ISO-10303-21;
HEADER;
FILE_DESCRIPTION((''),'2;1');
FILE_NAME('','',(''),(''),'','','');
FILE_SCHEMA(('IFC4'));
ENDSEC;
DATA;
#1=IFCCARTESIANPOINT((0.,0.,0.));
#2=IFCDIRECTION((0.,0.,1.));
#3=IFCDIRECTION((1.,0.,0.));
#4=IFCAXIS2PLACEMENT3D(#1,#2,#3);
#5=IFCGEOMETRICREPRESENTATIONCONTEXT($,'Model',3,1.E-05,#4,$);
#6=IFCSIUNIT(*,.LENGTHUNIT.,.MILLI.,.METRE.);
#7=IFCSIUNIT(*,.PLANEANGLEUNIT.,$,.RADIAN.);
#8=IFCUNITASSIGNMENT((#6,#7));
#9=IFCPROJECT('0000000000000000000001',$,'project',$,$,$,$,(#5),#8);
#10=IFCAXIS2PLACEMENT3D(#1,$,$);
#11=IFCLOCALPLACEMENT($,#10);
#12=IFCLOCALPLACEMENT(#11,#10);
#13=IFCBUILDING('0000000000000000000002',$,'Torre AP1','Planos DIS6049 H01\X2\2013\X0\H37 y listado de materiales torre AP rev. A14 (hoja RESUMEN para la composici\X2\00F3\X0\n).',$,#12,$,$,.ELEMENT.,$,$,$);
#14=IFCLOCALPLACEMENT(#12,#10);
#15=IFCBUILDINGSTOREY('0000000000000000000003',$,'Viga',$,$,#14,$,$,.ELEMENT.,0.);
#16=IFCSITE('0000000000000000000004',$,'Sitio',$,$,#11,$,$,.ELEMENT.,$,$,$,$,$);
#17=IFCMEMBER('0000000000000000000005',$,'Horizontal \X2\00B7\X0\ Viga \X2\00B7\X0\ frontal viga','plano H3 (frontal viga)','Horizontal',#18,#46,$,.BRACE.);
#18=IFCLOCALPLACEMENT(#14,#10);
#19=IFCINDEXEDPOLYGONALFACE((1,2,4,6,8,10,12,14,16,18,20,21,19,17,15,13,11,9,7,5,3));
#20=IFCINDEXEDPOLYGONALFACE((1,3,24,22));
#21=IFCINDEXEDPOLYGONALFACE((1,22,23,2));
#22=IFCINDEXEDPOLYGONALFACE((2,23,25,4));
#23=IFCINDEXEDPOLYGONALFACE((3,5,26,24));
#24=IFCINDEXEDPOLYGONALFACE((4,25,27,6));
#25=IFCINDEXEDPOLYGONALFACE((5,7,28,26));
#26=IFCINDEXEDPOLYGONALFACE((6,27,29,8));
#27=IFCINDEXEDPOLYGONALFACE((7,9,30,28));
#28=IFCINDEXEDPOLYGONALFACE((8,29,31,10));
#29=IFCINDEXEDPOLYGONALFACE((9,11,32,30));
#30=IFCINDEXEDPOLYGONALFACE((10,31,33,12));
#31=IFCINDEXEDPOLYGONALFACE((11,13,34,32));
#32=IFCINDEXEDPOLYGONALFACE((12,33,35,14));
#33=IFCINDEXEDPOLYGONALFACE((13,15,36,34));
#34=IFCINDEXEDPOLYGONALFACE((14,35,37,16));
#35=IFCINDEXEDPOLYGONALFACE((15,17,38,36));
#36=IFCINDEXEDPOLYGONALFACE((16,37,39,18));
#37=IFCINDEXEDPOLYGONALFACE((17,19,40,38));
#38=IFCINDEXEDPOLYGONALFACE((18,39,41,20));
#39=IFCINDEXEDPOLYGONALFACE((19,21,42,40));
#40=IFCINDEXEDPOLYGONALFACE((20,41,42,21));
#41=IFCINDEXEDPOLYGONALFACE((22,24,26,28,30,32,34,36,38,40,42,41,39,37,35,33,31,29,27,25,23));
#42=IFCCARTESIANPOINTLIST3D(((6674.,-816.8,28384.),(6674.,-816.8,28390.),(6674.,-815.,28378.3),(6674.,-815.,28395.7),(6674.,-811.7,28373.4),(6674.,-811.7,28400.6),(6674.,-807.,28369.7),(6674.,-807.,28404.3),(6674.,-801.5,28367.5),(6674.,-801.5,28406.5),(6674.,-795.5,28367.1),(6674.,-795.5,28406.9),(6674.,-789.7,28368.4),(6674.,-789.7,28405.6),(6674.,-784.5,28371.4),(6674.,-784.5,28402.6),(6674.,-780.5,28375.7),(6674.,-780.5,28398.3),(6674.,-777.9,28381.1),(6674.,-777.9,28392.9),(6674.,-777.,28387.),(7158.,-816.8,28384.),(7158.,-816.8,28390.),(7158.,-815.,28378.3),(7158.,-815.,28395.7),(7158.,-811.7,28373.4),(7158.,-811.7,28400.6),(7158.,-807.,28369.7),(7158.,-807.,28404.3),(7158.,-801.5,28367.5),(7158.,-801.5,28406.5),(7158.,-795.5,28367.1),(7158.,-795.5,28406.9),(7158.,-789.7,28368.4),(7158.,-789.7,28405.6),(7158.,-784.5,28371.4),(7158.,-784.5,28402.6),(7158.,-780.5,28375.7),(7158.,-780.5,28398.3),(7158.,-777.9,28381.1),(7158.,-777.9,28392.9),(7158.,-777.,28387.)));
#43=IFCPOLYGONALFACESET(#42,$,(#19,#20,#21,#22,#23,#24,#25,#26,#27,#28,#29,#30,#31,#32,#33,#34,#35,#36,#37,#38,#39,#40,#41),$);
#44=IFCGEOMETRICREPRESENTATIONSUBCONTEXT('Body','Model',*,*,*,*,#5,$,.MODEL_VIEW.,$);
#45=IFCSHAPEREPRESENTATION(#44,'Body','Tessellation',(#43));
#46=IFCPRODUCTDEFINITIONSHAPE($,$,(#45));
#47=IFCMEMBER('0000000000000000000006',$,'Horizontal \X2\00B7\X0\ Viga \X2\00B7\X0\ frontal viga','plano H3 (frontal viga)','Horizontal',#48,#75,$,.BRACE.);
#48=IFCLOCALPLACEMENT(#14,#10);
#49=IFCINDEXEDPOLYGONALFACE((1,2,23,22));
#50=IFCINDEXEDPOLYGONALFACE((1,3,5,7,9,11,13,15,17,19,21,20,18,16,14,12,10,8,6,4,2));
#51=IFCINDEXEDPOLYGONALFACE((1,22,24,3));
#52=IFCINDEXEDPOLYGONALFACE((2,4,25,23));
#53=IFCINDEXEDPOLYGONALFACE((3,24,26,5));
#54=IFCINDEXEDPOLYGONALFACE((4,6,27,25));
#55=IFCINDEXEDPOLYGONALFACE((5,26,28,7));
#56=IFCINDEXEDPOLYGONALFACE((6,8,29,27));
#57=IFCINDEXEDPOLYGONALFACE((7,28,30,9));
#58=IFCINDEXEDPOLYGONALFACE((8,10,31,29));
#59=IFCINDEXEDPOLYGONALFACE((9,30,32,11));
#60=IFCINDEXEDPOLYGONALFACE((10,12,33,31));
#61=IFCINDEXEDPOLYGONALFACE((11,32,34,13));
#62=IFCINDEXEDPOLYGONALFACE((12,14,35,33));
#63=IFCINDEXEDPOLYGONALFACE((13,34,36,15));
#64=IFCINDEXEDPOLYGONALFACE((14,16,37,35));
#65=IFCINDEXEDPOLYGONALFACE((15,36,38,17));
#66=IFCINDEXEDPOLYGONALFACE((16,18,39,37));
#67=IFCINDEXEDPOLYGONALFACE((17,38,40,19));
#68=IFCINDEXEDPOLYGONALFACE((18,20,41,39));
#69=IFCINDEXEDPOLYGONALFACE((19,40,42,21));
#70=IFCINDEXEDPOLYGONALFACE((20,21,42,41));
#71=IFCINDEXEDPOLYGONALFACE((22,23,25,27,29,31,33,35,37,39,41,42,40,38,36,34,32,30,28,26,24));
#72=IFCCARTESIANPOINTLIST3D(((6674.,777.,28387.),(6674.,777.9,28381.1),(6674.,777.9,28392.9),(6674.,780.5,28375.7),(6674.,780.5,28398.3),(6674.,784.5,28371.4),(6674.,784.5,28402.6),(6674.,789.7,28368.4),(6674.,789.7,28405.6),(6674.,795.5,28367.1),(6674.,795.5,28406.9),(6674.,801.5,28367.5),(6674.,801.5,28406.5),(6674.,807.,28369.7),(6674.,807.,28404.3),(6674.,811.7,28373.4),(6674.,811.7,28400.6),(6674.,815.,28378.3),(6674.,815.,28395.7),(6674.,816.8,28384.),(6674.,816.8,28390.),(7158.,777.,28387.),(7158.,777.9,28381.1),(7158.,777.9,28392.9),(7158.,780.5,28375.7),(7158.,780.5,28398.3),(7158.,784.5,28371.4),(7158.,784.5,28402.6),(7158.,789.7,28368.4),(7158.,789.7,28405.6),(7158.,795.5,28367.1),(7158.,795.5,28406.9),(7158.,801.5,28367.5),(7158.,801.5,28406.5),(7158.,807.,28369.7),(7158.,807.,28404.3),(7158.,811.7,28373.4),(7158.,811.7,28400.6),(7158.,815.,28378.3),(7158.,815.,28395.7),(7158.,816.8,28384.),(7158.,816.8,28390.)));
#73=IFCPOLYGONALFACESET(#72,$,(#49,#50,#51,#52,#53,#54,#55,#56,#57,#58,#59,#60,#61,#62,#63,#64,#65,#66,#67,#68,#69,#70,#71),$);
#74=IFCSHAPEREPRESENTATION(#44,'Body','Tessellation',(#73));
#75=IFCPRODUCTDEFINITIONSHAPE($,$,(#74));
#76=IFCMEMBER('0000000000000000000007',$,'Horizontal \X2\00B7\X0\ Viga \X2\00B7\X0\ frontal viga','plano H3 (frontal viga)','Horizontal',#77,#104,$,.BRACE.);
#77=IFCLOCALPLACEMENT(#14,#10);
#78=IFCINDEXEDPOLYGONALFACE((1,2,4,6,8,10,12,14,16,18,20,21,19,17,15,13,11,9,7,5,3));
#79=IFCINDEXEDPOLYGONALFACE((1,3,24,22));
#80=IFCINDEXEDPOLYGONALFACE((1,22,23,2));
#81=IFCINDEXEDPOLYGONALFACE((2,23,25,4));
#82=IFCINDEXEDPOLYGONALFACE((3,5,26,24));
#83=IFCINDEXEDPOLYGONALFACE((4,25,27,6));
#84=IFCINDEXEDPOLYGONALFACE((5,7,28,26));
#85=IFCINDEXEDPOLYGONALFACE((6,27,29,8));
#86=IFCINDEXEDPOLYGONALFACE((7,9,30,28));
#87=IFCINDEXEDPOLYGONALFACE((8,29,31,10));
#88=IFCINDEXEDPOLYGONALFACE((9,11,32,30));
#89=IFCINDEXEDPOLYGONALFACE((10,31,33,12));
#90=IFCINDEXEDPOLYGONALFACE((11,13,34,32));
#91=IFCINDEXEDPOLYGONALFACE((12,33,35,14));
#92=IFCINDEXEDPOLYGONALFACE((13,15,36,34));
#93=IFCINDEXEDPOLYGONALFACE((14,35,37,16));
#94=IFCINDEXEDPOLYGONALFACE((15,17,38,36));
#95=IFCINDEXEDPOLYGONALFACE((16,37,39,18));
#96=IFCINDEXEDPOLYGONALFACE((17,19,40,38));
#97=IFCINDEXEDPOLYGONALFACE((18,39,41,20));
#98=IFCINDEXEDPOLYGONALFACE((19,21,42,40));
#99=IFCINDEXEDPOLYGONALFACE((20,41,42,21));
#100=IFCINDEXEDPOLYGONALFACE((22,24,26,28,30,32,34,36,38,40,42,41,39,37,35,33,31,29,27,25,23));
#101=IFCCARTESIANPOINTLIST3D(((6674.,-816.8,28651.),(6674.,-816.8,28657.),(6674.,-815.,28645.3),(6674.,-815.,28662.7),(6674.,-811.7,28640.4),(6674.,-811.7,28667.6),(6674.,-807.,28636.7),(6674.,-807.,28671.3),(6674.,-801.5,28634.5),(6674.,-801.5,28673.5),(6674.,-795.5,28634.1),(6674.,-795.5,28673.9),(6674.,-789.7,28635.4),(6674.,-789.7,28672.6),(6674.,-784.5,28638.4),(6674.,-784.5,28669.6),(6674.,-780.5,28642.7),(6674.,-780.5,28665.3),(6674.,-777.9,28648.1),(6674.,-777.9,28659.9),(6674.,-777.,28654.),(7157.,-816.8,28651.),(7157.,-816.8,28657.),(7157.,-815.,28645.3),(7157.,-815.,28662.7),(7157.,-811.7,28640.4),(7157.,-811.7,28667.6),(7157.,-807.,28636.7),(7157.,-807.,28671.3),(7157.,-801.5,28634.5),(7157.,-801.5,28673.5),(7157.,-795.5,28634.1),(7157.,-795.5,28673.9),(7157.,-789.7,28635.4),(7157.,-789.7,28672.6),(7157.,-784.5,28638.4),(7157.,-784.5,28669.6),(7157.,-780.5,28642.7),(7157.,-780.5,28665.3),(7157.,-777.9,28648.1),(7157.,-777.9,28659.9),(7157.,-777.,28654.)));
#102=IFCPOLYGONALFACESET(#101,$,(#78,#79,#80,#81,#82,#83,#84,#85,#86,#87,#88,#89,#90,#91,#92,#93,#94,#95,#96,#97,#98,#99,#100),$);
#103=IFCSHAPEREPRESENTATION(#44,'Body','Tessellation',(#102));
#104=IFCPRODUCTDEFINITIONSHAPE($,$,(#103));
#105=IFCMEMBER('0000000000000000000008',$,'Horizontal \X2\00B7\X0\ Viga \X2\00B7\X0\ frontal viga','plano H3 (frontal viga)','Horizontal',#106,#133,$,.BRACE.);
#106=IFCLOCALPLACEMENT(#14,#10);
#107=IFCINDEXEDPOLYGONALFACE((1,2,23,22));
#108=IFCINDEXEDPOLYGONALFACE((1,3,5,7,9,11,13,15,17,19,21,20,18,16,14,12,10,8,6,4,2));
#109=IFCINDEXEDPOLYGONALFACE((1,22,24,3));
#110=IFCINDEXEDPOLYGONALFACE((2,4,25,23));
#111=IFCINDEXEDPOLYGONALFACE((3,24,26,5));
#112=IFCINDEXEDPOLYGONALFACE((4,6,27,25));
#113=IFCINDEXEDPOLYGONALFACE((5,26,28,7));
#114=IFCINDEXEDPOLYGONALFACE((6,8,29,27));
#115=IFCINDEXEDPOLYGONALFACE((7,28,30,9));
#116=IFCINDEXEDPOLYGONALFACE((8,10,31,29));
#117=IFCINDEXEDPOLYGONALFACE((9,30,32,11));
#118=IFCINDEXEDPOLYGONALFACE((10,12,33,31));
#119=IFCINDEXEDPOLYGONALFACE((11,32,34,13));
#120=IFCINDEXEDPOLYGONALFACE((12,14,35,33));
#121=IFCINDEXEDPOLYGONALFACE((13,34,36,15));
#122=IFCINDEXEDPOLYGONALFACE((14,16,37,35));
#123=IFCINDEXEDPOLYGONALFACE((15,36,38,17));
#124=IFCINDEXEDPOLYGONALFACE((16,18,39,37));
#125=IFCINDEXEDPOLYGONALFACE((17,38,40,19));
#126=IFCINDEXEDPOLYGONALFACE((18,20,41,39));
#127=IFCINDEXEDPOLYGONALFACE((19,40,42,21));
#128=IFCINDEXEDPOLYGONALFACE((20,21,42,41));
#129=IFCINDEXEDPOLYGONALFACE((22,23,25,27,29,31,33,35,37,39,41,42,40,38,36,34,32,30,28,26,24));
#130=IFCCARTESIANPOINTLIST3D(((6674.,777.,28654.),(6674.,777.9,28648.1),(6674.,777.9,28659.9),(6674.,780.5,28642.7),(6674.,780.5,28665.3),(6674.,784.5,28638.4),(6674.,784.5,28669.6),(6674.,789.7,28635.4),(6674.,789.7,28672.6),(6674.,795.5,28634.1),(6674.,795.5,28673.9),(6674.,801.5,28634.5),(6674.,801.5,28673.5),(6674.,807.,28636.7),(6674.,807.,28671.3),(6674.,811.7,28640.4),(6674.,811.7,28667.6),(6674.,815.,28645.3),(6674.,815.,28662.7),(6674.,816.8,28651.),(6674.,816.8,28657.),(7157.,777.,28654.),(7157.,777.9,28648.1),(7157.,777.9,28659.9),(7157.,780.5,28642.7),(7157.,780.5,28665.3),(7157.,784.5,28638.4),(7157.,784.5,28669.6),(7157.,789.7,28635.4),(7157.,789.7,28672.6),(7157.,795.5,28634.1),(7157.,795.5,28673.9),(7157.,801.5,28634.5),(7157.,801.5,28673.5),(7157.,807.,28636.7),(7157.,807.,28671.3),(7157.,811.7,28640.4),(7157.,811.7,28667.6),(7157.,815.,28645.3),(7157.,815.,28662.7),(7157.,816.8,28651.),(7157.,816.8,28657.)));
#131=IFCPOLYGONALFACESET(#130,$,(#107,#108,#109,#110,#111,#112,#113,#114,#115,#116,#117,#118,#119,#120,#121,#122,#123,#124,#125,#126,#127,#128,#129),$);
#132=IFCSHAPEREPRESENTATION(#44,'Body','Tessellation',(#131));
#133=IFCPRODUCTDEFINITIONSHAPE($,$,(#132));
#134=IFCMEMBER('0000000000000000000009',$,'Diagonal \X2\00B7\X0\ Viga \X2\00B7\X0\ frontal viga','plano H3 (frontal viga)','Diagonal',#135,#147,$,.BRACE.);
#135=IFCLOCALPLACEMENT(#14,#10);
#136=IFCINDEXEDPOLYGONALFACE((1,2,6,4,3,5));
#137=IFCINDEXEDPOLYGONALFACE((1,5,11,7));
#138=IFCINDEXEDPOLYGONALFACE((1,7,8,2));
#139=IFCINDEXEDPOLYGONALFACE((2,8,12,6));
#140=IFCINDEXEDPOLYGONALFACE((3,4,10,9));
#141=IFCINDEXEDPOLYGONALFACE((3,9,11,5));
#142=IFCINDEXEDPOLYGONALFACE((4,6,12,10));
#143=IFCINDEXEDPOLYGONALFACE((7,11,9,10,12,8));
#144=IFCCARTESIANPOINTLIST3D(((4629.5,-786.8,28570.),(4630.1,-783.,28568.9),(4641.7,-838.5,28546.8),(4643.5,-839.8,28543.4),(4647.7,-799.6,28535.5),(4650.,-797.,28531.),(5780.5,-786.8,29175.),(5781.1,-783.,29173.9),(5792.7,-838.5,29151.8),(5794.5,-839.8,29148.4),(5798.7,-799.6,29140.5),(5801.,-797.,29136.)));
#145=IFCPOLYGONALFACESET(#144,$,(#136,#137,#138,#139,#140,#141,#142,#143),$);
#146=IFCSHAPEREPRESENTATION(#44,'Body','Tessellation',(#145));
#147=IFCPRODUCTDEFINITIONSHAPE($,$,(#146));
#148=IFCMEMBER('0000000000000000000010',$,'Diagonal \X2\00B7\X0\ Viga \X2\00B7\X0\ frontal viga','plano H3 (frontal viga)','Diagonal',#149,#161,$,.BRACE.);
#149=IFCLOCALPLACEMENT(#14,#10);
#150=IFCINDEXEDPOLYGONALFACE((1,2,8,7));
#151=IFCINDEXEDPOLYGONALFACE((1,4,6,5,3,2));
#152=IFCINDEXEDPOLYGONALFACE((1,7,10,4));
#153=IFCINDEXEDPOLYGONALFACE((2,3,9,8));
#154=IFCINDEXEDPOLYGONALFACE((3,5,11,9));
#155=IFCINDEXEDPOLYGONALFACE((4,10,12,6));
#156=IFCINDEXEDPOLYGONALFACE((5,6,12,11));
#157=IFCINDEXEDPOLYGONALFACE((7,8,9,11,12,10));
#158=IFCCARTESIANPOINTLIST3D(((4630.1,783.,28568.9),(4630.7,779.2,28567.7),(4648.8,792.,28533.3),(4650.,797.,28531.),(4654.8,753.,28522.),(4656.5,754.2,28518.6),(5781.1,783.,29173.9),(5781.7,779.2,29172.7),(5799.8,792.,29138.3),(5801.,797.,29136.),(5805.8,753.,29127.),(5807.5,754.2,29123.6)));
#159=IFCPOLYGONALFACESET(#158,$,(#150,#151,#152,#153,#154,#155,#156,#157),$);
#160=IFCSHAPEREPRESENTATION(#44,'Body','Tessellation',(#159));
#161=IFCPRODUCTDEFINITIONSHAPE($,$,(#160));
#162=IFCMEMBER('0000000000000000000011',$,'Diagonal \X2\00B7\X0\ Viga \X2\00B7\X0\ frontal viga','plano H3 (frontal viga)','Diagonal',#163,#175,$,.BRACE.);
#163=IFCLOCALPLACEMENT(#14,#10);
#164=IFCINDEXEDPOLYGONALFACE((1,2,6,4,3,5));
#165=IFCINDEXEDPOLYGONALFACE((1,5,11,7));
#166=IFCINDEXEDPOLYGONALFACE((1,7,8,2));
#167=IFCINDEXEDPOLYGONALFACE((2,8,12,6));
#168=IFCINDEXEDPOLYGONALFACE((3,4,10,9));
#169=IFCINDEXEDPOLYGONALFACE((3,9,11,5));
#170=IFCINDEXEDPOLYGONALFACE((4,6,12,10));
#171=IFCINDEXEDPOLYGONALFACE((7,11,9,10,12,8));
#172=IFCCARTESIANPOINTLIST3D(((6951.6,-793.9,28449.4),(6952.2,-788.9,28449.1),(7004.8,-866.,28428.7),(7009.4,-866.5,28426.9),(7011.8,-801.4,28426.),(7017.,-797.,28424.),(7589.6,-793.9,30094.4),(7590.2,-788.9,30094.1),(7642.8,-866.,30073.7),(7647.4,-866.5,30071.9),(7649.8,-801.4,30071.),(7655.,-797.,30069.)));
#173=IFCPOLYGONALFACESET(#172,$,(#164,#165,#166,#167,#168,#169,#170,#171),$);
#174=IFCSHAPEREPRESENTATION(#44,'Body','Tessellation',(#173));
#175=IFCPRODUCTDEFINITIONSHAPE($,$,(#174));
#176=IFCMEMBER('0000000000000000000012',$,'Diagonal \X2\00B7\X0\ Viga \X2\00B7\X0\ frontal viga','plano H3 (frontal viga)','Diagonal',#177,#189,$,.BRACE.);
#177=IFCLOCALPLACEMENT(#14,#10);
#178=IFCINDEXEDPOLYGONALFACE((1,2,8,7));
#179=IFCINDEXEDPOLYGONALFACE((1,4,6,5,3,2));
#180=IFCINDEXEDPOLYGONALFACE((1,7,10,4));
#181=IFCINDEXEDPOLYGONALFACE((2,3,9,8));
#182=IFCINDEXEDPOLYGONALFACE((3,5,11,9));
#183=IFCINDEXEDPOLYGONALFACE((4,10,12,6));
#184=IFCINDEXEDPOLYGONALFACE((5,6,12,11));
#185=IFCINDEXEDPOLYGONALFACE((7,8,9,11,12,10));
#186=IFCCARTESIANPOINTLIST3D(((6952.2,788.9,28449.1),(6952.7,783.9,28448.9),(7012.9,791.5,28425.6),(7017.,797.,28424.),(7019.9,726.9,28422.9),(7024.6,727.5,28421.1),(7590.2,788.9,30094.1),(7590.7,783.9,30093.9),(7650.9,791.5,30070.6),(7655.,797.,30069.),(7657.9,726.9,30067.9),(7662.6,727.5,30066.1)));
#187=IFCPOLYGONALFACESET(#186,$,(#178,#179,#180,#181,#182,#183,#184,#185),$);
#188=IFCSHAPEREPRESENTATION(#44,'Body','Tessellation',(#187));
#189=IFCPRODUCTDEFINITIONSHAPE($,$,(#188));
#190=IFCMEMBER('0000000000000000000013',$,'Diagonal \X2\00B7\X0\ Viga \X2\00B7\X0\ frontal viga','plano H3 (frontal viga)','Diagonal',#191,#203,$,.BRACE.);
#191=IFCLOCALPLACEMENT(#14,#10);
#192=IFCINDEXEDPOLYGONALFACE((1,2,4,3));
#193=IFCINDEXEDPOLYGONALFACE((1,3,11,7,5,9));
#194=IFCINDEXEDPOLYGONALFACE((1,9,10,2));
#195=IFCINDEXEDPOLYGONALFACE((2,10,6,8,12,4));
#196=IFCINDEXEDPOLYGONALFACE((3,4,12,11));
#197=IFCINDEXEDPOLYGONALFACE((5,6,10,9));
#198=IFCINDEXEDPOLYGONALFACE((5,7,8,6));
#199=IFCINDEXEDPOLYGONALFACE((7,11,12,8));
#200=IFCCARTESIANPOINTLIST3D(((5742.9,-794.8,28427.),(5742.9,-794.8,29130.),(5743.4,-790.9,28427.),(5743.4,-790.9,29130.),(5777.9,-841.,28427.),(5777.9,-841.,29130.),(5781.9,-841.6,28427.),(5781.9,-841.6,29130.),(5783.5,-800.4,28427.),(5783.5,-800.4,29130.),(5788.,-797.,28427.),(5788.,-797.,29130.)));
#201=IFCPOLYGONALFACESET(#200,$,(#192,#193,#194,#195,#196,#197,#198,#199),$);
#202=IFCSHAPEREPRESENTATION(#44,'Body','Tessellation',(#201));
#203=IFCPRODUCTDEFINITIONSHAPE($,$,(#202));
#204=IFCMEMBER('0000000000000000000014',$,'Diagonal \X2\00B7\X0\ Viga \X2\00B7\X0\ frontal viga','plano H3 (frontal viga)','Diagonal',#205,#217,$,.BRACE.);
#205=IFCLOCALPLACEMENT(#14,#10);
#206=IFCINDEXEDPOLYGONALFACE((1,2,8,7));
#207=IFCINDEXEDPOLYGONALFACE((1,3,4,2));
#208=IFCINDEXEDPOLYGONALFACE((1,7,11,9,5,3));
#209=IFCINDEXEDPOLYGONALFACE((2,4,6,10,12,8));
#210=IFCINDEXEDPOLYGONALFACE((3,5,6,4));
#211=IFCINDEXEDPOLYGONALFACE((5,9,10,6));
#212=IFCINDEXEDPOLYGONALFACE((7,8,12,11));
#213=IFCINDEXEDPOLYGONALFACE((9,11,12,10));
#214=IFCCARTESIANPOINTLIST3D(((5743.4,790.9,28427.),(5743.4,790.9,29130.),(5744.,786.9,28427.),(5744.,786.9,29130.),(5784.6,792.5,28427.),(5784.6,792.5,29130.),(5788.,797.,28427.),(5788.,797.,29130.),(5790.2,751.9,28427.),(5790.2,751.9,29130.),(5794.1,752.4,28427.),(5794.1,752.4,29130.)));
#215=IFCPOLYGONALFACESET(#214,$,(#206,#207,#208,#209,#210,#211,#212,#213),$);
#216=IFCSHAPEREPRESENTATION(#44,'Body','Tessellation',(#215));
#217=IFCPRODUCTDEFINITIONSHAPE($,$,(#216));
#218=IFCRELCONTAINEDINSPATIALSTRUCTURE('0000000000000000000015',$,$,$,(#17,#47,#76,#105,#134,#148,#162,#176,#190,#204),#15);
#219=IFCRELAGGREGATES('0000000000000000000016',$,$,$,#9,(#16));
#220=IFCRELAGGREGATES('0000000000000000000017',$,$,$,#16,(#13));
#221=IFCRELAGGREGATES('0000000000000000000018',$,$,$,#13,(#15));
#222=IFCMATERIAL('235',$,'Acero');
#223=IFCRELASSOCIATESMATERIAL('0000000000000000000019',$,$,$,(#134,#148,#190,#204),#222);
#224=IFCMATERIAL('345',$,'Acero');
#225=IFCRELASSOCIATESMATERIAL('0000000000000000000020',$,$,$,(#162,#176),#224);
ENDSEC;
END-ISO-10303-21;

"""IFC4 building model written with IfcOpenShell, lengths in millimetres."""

from ifc_helpers import new_model, si_unit, frame, frame_2d, origin, origin_with_axes, place, context, subcontext, project, spatial, circle, l_section, extrude, material, element, save


model = new_model("IFC4")

# Units and contexts
model_context = context("Model", 3, precision=1e-05, world=origin_with_axes())
body_context = subcontext(model_context, "Body", "Model", "MODEL_VIEW")
ifc_project = project(units=[si_unit("LENGTHUNIT", "METRE", prefix="MILLI"), si_unit("PLANEANGLEUNIT", "RADIAN")], contexts=[model_context])

# Site, building, storey
site_placement = place(None, origin())
site = spatial("IfcSite", under=ifc_project, at=site_placement, Name="Sitio", CompositionType="ELEMENT")
building_placement = place(site_placement, origin())
building = spatial("IfcBuilding", under=site, at=building_placement, Name="Torre AP1", Description="Planos DIS6049 H01–H37 y listado de materiales torre AP rev. A14 (hoja RESUMEN para la composición).", CompositionType="ELEMENT")
storey_placement = place(building_placement, origin())
storey = spatial("IfcBuildingStorey", under=building, at=storey_placement, Name="Viga", CompositionType="ELEMENT", Elevation=0.0)

# Members
for number, where, z_axis, x_axis, name in (
    (1, (6674.0, -797.0, 28387.0), (1.0, 0.0, 0.0), (0.0, 1.0, 0.0), "Horizontal · Viga · frontal viga"),
    (2, (6674.0, 797.0, 28387.0), (1.0, 0.0, 0.0), (0.0, -1.0, 0.0), "Horizontal · Viga · frontal viga"),
):
    element("IfcMember", number, at=place(storey_placement, frame(where, z_axis=z_axis, x_axis=x_axis)), inside=storey, Name=name, Description="plano H3 (frontal viga)", ObjectType="Horizontal", PredefinedType="BRACE", context=body_context, shape_type="SweptSolid", body=[
        extrude(circle(Radius=20.0), None, (0.0, 0.0, 1.0), 484.0),
    ])
for number, where, z_axis, x_axis, name in (
    (3, (6674.0, -797.0, 28654.0), (1.0, 0.0, 0.0), (0.0, 1.0, 0.0), "Horizontal · Viga · frontal viga"),
    (4, (6674.0, 797.0, 28654.0), (1.0, 0.0, 0.0), (0.0, -1.0, 0.0), "Horizontal · Viga · frontal viga"),
):
    element("IfcMember", number, at=place(storey_placement, frame(where, z_axis=z_axis, x_axis=x_axis)), inside=storey, Name=name, Description="plano H3 (frontal viga)", ObjectType="Horizontal", PredefinedType="BRACE", context=body_context, shape_type="SweptSolid", body=[
        extrude(circle(Radius=20.0), None, (0.0, 0.0, 1.0), 483.0),
    ])
ifc_material_1 = material(Name="235", Category="Acero")
for number, where, z_axis, x_axis, name in (
    (5, (4650.0, -797.0, 28531.0), (0.885168, 0.0, 0.465271), (-0.442122, 0.311502, 0.841127), "Diagonal · Viga · frontal viga"),
    (6, (4650.0, 797.0, 28531.0), (0.885168, 0.0, 0.465271), (-0.442122, -0.311502, 0.841127), "Diagonal · Viga · frontal viga"),
):
    element("IfcMember", number, at=place(storey_placement, frame(where, z_axis=z_axis, x_axis=x_axis)), inside=storey, material=ifc_material_1, Name=name, Description="plano H3 (frontal viga)", ObjectType="Diagonal", PredefinedType="BRACE", context=body_context, shape_type="SweptSolid", body=[
        extrude(l_section(Depth=45.0, Width=45.0, Thickness=4.0, at=frame_2d((22.5, 22.5))), None, (0.0, 0.0, 1.0), 1300.3),
    ])
ifc_material_2 = material(Name="345", Category="Acero")
for number, where, z_axis, x_axis, name in (
    (7, (7017.0, -797.0, 28424.0), (0.361598, 0.0, 0.932334), (-0.926068, 0.115744, 0.359168), "Diagonal · Viga · frontal viga"),
    (8, (7017.0, 797.0, 28424.0), (0.361598, 0.0, 0.932334), (-0.926068, -0.115744, 0.359168), "Diagonal · Viga · frontal viga"),
):
    element("IfcMember", number, at=place(storey_placement, frame(where, z_axis=z_axis, x_axis=x_axis)), inside=storey, material=ifc_material_2, Name=name, Description="plano H3 (frontal viga)", ObjectType="Diagonal", PredefinedType="BRACE", context=body_context, shape_type="SweptSolid", body=[
        extrude(l_section(Depth=70.0, Width=70.0, Thickness=5.0, at=frame_2d((35.0, 35.0))), None, (0.0, 0.0, 1.0), 1764.4),
    ])
for number, where, z_axis, x_axis, name in (
    (9, (5788.0, -797.0, 28427.0), (0.0, 0.0, 1.0), (-0.990652, 0.136412, 0.0), "Diagonal · Viga · frontal viga"),
    (10, (5788.0, 797.0, 28427.0), (0.0, 0.0, 1.0), (-0.990652, -0.136412, 0.0), "Diagonal · Viga · frontal viga"),
):
    element("IfcMember", number, at=place(storey_placement, frame(where, z_axis=z_axis, x_axis=x_axis)), inside=storey, material=ifc_material_1, Name=name, Description="plano H3 (frontal viga)", ObjectType="Diagonal", PredefinedType="BRACE", context=body_context, shape_type="SweptSolid", body=[
        extrude(l_section(Depth=45.0, Width=45.0, Thickness=4.0, at=frame_2d((22.5, 22.5))), None, (0.0, 0.0, 1.0), 703.0),
    ])

save(model, "model.ifc")
